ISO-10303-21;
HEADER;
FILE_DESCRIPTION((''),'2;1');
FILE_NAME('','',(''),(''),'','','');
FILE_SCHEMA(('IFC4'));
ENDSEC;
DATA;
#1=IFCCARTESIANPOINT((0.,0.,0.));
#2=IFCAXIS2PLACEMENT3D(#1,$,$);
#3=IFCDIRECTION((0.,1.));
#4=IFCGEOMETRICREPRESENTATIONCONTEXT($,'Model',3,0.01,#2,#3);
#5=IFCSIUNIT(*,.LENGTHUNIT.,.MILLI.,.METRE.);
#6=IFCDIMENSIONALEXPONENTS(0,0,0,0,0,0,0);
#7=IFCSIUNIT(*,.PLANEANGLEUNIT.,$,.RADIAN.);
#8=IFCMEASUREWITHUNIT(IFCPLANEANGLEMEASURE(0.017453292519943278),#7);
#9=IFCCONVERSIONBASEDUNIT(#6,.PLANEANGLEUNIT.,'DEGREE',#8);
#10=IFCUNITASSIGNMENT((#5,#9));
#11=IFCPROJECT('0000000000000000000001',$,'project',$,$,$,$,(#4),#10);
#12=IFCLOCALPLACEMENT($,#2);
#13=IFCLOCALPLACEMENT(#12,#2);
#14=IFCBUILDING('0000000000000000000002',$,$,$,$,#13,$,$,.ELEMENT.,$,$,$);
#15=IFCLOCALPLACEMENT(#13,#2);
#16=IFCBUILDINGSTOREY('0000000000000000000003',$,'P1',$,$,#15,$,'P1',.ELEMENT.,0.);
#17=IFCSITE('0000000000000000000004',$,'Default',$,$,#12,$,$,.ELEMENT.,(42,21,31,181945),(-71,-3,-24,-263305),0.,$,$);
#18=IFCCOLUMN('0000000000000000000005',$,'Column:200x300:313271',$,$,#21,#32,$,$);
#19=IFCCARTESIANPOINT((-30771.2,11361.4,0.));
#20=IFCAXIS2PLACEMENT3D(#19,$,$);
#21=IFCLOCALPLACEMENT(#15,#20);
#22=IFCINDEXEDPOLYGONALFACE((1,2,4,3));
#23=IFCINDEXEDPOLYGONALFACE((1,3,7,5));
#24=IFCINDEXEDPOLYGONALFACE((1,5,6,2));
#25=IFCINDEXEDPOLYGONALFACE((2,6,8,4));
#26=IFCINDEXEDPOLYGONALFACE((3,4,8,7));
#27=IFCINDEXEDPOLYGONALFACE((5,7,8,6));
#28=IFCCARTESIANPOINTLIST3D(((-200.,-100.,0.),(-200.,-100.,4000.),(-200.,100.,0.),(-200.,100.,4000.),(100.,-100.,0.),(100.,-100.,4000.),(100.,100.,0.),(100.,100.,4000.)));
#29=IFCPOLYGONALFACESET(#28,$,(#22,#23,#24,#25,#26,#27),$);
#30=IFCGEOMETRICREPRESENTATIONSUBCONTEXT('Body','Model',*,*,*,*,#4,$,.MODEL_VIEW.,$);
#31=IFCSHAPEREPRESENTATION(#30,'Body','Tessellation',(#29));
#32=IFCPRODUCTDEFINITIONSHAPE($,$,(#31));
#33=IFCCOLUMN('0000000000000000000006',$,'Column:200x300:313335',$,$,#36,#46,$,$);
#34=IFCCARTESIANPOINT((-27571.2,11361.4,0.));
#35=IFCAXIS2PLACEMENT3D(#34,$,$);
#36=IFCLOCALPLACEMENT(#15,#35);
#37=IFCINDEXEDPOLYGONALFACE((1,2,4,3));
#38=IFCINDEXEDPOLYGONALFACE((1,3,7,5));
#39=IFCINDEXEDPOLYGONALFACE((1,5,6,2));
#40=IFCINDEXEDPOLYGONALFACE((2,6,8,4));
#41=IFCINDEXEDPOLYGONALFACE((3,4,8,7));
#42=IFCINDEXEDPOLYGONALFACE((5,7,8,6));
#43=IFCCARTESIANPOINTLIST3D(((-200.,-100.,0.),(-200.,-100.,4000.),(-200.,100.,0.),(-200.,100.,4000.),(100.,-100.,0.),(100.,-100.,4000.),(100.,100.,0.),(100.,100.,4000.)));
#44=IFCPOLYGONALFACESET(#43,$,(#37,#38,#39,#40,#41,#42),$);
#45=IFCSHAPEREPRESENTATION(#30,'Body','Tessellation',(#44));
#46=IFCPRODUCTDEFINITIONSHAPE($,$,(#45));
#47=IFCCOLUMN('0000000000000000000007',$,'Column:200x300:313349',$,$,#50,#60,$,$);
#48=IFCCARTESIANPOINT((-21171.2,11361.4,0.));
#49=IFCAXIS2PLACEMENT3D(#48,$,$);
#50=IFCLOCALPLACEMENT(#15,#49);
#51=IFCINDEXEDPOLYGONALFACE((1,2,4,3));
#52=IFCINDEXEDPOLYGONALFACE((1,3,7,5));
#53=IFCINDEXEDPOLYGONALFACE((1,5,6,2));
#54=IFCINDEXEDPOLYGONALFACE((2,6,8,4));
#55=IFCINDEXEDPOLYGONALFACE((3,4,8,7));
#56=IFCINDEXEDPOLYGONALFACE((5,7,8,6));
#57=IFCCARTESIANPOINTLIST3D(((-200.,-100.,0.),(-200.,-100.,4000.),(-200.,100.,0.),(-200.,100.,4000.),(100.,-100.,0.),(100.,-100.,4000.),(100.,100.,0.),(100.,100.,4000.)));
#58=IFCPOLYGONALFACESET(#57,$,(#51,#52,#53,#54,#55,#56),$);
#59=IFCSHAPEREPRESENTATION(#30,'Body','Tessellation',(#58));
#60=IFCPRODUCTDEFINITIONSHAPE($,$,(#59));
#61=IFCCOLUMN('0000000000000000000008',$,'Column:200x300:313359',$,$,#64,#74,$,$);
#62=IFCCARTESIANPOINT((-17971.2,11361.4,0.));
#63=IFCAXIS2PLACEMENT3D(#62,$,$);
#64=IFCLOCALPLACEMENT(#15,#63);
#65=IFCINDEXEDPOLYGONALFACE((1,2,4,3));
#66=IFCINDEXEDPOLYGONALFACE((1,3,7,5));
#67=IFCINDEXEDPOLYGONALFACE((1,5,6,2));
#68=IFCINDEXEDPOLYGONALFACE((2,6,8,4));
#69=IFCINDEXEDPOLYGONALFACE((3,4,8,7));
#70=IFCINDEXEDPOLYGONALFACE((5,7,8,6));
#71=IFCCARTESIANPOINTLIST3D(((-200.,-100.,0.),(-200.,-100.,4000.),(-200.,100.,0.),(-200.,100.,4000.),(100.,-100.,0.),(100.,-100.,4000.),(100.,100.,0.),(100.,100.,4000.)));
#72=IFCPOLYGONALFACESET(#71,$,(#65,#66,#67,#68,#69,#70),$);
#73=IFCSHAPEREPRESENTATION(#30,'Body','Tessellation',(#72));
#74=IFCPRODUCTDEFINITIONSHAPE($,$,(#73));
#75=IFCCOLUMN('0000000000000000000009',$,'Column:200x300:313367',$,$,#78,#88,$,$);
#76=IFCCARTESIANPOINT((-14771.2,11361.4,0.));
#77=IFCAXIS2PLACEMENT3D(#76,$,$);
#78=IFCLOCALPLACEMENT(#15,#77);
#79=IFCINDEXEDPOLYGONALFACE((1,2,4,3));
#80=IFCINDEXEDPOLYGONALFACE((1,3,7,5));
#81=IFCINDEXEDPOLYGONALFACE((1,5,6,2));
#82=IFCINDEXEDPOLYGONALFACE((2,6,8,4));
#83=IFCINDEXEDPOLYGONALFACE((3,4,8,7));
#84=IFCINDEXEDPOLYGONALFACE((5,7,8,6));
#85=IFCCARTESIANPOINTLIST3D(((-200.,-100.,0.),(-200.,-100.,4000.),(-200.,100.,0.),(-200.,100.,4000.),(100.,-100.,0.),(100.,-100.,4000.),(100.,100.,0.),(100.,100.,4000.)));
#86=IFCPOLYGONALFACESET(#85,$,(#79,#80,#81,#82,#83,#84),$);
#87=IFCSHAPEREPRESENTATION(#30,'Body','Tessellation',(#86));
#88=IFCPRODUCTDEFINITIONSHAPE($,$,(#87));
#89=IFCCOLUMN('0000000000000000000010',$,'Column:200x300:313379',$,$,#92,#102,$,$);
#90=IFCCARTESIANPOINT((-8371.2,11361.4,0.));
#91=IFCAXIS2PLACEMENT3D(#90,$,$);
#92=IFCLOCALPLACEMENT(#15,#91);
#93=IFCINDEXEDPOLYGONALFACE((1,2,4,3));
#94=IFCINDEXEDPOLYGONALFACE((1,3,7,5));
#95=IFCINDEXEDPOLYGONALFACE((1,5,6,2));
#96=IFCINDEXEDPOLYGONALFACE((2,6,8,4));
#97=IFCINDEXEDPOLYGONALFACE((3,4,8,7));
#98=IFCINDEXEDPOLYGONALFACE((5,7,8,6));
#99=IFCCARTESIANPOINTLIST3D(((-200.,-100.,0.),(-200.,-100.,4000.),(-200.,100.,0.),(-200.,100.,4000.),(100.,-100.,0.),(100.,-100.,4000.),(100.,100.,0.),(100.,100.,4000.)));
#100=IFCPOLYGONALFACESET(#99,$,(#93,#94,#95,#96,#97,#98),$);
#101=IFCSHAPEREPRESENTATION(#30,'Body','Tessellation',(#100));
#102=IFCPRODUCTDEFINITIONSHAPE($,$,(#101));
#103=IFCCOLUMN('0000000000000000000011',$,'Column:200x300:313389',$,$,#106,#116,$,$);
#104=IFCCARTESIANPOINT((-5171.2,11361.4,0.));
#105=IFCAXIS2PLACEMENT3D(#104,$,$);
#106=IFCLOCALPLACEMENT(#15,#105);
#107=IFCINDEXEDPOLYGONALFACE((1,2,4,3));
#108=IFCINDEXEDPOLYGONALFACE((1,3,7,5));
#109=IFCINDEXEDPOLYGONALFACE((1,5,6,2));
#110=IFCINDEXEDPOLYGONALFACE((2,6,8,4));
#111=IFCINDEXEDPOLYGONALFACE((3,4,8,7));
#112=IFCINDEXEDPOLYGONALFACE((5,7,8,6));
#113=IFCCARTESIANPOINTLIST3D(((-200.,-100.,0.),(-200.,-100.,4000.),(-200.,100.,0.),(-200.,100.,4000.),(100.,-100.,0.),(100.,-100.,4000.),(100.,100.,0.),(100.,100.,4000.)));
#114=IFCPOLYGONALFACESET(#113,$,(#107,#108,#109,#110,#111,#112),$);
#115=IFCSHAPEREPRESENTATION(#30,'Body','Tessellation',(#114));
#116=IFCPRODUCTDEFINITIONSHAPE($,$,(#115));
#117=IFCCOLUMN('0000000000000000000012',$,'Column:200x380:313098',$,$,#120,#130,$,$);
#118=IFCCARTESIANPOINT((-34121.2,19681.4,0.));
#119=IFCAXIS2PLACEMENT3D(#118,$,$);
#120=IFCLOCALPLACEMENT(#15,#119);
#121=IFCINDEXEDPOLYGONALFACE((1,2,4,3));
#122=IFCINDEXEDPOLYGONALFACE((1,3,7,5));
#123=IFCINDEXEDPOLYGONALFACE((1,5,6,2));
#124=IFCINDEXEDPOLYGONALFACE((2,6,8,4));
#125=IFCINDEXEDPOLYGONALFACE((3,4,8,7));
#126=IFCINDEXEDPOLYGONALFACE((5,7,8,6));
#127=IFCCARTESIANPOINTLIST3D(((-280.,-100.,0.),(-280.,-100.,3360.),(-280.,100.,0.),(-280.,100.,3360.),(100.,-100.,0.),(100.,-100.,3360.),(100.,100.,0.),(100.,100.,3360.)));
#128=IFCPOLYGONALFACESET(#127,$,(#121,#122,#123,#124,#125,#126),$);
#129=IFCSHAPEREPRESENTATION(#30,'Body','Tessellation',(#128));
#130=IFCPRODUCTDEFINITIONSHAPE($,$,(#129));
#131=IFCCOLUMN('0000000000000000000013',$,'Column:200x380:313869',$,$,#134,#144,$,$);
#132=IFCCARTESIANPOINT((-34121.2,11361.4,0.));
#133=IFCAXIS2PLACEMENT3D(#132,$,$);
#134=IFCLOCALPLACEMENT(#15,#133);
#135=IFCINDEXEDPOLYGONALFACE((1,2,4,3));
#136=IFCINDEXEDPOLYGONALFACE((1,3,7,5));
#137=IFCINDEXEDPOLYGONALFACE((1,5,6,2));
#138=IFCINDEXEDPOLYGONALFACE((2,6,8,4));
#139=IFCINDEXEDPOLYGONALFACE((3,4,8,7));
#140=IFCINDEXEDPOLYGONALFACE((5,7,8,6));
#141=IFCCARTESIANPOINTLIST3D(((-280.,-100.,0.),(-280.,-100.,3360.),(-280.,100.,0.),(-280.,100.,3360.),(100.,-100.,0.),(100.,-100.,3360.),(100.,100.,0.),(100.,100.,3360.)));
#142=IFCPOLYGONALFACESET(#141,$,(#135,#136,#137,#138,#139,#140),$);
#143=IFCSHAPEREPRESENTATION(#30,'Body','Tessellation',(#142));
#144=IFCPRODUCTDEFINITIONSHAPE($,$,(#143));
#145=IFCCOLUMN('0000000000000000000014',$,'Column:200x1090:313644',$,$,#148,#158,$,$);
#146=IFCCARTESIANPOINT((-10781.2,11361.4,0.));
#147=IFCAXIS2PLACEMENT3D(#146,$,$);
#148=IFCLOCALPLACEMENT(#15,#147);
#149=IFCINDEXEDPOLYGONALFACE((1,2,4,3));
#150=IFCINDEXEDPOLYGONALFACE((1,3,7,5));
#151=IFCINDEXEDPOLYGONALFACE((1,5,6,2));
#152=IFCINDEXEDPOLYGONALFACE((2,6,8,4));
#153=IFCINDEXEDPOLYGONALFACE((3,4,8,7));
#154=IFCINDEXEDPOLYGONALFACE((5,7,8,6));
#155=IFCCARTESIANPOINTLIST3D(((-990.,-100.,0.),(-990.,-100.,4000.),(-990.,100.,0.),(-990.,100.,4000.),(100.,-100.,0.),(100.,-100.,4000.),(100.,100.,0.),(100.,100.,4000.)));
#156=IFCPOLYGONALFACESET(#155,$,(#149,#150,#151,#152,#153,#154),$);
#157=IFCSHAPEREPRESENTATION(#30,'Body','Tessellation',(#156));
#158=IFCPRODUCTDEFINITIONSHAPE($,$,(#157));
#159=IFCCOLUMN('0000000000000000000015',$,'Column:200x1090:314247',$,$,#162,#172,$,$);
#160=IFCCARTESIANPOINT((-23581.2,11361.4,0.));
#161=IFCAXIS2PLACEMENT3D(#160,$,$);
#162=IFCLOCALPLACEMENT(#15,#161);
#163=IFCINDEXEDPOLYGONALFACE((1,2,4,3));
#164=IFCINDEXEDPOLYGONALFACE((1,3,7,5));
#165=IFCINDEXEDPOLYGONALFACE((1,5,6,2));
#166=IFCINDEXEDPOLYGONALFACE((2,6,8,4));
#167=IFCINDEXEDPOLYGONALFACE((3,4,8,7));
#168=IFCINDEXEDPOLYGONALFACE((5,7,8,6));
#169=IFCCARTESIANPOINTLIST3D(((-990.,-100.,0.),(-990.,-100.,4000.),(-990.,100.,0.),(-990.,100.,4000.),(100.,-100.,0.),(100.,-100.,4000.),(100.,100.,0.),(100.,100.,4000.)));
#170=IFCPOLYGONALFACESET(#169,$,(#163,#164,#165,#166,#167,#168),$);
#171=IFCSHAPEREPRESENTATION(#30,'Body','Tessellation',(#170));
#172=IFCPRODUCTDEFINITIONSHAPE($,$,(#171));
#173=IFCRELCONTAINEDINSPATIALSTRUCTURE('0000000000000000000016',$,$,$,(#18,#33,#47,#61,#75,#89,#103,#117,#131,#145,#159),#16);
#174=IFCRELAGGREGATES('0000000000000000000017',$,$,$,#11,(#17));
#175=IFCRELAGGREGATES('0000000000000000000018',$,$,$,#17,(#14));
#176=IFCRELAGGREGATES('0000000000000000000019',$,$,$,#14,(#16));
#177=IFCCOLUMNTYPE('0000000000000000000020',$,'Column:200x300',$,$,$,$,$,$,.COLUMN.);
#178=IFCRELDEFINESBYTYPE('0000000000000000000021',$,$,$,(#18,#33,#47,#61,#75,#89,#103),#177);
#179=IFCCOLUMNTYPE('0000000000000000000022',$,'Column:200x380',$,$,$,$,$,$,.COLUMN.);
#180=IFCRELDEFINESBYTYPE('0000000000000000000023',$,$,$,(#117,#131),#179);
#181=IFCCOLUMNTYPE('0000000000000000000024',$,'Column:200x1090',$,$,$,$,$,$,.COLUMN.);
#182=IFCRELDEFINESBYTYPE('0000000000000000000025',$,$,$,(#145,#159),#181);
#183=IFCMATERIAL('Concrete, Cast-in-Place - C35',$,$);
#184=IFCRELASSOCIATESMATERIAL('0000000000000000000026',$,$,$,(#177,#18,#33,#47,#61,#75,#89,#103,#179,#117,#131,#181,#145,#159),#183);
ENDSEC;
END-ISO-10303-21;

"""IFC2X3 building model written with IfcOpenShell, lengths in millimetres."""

from ifc_helpers import new_model, entity, si_unit, converted_unit, direction, frame, origin, origin_2d_with_axis, place, context, subcontext, project, spatial, rectangle, extrude, source, transform, mapped, material, type_object, type_shapes, element, save


model = new_model("IFC2X3")

# Units and contexts
model_context = context("Model", 3, precision=0.01, world=origin(), true_north=direction((0.0, 1.0)))
body_context = subcontext(model_context, "Body", "Model", "MODEL_VIEW")
ifc_project = project(units=[si_unit("LENGTHUNIT", "METRE", prefix="MILLI"), converted_unit("PLANEANGLEUNIT", "DEGREE", entity("IfcPlaneAngleMeasure", 0.017453292519943278), si_unit("PLANEANGLEUNIT", "RADIAN"), dimensions=[0, 0, 0, 0, 0, 0, 0])], contexts=[model_context])

# Site, building, storey
site_placement = place(None, origin())
site = spatial("IfcSite", under=ifc_project, at=site_placement, Name="Default", CompositionType="ELEMENT", RefLatitude=(42, 21, 31, 181945), RefLongitude=(-71, -3, -24, -263305), RefElevation=0.0)
building_placement = place(site_placement, origin())
building = spatial("IfcBuilding", under=site, at=building_placement, CompositionType="ELEMENT")
storey_placement = place(building_placement, origin())
storey = spatial("IfcBuildingStorey", under=building, at=storey_placement, Name="P1", LongName="P1", CompositionType="ELEMENT", Elevation=0.0)

# Columns
ifc_material_1 = material(Name="Concrete, Cast-in-Place - C35")
column_type_1 = type_object("IfcColumnType", Name="Column:200x300", PredefinedType="COLUMN", material=ifc_material_1)
shared_shape_1 = source(origin(), body_context, "Body", "SweptSolid", [
    extrude(rectangle(XDim=300.0, YDim=200.0, at=origin_2d_with_axis()), frame((-50.0, 0.0, 0.0), z_axis=(0.0, 0.0, 1.0), x_axis=(-1.0, 0.0, 0.0)), (0.0, 0.0, 1.0), 4000.0),
])
type_shapes(column_type_1, [shared_shape_1])
for number, where, name in (
    (1, (-30771.2, 11361.4, 0.0), "Column:200x300:313271"),
    (2, (-27571.2, 11361.4, 0.0), "Column:200x300:313335"),
    (3, (-21171.2, 11361.4, 0.0), "Column:200x300:313349"),
    (4, (-17971.2, 11361.4, 0.0), "Column:200x300:313359"),
    (5, (-14771.2, 11361.4, 0.0), "Column:200x300:313367"),
    (6, (-8371.2, 11361.4, 0.0), "Column:200x300:313379"),
    (7, (-5171.2, 11361.4, 0.0), "Column:200x300:313389"),
):
    element("IfcColumn", number, at=place(storey_placement, frame(where)), inside=storey, type_object=column_type_1, material=ifc_material_1, Name=name, context=body_context, shape_type="MappedRepresentation", body=[
        mapped(shared_shape_1, transform((0.0, 0.0, 0.0), scale=1.0)),
    ])
column_type_2 = type_object("IfcColumnType", Name="Column:200x380", PredefinedType="COLUMN", material=ifc_material_1)
shared_shape_2 = source(origin(), body_context, "Body", "SweptSolid", [
    extrude(rectangle(XDim=380.0, YDim=200.0, at=origin_2d_with_axis()), frame((-90.0, 0.0, 0.0), z_axis=(0.0, 0.0, 1.0), x_axis=(-1.0, 0.0, 0.0)), (0.0, 0.0, 1.0), 3360.0),
])
type_shapes(column_type_2, [shared_shape_2])
for number, where, name in (
    (8, (-34121.2, 19681.4, 0.0), "Column:200x380:313098"),
    (9, (-34121.2, 11361.4, 0.0), "Column:200x380:313869"),
):
    element("IfcColumn", number, at=place(storey_placement, frame(where)), inside=storey, type_object=column_type_2, material=ifc_material_1, Name=name, context=body_context, shape_type="MappedRepresentation", body=[
        mapped(shared_shape_2, transform((0.0, 0.0, 0.0), scale=1.0)),
    ])
column_type_3 = type_object("IfcColumnType", Name="Column:200x1090", PredefinedType="COLUMN", material=ifc_material_1)
shared_shape_3 = source(origin(), body_context, "Body", "SweptSolid", [
    extrude(rectangle(XDim=1090.0, YDim=200.0, at=origin_2d_with_axis()), frame((-445.0, 0.0, 0.0), z_axis=(0.0, 0.0, 1.0), x_axis=(-1.0, 0.0, 0.0)), (0.0, 0.0, 1.0), 4000.0),
])
type_shapes(column_type_3, [shared_shape_3])
for number, where, name in (
    (10, (-10781.2, 11361.4, 0.0), "Column:200x1090:313644"),
    (11, (-23581.2, 11361.4, 0.0), "Column:200x1090:314247"),
):
    element("IfcColumn", number, at=place(storey_placement, frame(where)), inside=storey, type_object=column_type_3, material=ifc_material_1, Name=name, context=body_context, shape_type="MappedRepresentation", body=[
        mapped(shared_shape_3, transform((0.0, 0.0, 0.0), scale=1.0)),
    ])

save(model, "model.ifc")
